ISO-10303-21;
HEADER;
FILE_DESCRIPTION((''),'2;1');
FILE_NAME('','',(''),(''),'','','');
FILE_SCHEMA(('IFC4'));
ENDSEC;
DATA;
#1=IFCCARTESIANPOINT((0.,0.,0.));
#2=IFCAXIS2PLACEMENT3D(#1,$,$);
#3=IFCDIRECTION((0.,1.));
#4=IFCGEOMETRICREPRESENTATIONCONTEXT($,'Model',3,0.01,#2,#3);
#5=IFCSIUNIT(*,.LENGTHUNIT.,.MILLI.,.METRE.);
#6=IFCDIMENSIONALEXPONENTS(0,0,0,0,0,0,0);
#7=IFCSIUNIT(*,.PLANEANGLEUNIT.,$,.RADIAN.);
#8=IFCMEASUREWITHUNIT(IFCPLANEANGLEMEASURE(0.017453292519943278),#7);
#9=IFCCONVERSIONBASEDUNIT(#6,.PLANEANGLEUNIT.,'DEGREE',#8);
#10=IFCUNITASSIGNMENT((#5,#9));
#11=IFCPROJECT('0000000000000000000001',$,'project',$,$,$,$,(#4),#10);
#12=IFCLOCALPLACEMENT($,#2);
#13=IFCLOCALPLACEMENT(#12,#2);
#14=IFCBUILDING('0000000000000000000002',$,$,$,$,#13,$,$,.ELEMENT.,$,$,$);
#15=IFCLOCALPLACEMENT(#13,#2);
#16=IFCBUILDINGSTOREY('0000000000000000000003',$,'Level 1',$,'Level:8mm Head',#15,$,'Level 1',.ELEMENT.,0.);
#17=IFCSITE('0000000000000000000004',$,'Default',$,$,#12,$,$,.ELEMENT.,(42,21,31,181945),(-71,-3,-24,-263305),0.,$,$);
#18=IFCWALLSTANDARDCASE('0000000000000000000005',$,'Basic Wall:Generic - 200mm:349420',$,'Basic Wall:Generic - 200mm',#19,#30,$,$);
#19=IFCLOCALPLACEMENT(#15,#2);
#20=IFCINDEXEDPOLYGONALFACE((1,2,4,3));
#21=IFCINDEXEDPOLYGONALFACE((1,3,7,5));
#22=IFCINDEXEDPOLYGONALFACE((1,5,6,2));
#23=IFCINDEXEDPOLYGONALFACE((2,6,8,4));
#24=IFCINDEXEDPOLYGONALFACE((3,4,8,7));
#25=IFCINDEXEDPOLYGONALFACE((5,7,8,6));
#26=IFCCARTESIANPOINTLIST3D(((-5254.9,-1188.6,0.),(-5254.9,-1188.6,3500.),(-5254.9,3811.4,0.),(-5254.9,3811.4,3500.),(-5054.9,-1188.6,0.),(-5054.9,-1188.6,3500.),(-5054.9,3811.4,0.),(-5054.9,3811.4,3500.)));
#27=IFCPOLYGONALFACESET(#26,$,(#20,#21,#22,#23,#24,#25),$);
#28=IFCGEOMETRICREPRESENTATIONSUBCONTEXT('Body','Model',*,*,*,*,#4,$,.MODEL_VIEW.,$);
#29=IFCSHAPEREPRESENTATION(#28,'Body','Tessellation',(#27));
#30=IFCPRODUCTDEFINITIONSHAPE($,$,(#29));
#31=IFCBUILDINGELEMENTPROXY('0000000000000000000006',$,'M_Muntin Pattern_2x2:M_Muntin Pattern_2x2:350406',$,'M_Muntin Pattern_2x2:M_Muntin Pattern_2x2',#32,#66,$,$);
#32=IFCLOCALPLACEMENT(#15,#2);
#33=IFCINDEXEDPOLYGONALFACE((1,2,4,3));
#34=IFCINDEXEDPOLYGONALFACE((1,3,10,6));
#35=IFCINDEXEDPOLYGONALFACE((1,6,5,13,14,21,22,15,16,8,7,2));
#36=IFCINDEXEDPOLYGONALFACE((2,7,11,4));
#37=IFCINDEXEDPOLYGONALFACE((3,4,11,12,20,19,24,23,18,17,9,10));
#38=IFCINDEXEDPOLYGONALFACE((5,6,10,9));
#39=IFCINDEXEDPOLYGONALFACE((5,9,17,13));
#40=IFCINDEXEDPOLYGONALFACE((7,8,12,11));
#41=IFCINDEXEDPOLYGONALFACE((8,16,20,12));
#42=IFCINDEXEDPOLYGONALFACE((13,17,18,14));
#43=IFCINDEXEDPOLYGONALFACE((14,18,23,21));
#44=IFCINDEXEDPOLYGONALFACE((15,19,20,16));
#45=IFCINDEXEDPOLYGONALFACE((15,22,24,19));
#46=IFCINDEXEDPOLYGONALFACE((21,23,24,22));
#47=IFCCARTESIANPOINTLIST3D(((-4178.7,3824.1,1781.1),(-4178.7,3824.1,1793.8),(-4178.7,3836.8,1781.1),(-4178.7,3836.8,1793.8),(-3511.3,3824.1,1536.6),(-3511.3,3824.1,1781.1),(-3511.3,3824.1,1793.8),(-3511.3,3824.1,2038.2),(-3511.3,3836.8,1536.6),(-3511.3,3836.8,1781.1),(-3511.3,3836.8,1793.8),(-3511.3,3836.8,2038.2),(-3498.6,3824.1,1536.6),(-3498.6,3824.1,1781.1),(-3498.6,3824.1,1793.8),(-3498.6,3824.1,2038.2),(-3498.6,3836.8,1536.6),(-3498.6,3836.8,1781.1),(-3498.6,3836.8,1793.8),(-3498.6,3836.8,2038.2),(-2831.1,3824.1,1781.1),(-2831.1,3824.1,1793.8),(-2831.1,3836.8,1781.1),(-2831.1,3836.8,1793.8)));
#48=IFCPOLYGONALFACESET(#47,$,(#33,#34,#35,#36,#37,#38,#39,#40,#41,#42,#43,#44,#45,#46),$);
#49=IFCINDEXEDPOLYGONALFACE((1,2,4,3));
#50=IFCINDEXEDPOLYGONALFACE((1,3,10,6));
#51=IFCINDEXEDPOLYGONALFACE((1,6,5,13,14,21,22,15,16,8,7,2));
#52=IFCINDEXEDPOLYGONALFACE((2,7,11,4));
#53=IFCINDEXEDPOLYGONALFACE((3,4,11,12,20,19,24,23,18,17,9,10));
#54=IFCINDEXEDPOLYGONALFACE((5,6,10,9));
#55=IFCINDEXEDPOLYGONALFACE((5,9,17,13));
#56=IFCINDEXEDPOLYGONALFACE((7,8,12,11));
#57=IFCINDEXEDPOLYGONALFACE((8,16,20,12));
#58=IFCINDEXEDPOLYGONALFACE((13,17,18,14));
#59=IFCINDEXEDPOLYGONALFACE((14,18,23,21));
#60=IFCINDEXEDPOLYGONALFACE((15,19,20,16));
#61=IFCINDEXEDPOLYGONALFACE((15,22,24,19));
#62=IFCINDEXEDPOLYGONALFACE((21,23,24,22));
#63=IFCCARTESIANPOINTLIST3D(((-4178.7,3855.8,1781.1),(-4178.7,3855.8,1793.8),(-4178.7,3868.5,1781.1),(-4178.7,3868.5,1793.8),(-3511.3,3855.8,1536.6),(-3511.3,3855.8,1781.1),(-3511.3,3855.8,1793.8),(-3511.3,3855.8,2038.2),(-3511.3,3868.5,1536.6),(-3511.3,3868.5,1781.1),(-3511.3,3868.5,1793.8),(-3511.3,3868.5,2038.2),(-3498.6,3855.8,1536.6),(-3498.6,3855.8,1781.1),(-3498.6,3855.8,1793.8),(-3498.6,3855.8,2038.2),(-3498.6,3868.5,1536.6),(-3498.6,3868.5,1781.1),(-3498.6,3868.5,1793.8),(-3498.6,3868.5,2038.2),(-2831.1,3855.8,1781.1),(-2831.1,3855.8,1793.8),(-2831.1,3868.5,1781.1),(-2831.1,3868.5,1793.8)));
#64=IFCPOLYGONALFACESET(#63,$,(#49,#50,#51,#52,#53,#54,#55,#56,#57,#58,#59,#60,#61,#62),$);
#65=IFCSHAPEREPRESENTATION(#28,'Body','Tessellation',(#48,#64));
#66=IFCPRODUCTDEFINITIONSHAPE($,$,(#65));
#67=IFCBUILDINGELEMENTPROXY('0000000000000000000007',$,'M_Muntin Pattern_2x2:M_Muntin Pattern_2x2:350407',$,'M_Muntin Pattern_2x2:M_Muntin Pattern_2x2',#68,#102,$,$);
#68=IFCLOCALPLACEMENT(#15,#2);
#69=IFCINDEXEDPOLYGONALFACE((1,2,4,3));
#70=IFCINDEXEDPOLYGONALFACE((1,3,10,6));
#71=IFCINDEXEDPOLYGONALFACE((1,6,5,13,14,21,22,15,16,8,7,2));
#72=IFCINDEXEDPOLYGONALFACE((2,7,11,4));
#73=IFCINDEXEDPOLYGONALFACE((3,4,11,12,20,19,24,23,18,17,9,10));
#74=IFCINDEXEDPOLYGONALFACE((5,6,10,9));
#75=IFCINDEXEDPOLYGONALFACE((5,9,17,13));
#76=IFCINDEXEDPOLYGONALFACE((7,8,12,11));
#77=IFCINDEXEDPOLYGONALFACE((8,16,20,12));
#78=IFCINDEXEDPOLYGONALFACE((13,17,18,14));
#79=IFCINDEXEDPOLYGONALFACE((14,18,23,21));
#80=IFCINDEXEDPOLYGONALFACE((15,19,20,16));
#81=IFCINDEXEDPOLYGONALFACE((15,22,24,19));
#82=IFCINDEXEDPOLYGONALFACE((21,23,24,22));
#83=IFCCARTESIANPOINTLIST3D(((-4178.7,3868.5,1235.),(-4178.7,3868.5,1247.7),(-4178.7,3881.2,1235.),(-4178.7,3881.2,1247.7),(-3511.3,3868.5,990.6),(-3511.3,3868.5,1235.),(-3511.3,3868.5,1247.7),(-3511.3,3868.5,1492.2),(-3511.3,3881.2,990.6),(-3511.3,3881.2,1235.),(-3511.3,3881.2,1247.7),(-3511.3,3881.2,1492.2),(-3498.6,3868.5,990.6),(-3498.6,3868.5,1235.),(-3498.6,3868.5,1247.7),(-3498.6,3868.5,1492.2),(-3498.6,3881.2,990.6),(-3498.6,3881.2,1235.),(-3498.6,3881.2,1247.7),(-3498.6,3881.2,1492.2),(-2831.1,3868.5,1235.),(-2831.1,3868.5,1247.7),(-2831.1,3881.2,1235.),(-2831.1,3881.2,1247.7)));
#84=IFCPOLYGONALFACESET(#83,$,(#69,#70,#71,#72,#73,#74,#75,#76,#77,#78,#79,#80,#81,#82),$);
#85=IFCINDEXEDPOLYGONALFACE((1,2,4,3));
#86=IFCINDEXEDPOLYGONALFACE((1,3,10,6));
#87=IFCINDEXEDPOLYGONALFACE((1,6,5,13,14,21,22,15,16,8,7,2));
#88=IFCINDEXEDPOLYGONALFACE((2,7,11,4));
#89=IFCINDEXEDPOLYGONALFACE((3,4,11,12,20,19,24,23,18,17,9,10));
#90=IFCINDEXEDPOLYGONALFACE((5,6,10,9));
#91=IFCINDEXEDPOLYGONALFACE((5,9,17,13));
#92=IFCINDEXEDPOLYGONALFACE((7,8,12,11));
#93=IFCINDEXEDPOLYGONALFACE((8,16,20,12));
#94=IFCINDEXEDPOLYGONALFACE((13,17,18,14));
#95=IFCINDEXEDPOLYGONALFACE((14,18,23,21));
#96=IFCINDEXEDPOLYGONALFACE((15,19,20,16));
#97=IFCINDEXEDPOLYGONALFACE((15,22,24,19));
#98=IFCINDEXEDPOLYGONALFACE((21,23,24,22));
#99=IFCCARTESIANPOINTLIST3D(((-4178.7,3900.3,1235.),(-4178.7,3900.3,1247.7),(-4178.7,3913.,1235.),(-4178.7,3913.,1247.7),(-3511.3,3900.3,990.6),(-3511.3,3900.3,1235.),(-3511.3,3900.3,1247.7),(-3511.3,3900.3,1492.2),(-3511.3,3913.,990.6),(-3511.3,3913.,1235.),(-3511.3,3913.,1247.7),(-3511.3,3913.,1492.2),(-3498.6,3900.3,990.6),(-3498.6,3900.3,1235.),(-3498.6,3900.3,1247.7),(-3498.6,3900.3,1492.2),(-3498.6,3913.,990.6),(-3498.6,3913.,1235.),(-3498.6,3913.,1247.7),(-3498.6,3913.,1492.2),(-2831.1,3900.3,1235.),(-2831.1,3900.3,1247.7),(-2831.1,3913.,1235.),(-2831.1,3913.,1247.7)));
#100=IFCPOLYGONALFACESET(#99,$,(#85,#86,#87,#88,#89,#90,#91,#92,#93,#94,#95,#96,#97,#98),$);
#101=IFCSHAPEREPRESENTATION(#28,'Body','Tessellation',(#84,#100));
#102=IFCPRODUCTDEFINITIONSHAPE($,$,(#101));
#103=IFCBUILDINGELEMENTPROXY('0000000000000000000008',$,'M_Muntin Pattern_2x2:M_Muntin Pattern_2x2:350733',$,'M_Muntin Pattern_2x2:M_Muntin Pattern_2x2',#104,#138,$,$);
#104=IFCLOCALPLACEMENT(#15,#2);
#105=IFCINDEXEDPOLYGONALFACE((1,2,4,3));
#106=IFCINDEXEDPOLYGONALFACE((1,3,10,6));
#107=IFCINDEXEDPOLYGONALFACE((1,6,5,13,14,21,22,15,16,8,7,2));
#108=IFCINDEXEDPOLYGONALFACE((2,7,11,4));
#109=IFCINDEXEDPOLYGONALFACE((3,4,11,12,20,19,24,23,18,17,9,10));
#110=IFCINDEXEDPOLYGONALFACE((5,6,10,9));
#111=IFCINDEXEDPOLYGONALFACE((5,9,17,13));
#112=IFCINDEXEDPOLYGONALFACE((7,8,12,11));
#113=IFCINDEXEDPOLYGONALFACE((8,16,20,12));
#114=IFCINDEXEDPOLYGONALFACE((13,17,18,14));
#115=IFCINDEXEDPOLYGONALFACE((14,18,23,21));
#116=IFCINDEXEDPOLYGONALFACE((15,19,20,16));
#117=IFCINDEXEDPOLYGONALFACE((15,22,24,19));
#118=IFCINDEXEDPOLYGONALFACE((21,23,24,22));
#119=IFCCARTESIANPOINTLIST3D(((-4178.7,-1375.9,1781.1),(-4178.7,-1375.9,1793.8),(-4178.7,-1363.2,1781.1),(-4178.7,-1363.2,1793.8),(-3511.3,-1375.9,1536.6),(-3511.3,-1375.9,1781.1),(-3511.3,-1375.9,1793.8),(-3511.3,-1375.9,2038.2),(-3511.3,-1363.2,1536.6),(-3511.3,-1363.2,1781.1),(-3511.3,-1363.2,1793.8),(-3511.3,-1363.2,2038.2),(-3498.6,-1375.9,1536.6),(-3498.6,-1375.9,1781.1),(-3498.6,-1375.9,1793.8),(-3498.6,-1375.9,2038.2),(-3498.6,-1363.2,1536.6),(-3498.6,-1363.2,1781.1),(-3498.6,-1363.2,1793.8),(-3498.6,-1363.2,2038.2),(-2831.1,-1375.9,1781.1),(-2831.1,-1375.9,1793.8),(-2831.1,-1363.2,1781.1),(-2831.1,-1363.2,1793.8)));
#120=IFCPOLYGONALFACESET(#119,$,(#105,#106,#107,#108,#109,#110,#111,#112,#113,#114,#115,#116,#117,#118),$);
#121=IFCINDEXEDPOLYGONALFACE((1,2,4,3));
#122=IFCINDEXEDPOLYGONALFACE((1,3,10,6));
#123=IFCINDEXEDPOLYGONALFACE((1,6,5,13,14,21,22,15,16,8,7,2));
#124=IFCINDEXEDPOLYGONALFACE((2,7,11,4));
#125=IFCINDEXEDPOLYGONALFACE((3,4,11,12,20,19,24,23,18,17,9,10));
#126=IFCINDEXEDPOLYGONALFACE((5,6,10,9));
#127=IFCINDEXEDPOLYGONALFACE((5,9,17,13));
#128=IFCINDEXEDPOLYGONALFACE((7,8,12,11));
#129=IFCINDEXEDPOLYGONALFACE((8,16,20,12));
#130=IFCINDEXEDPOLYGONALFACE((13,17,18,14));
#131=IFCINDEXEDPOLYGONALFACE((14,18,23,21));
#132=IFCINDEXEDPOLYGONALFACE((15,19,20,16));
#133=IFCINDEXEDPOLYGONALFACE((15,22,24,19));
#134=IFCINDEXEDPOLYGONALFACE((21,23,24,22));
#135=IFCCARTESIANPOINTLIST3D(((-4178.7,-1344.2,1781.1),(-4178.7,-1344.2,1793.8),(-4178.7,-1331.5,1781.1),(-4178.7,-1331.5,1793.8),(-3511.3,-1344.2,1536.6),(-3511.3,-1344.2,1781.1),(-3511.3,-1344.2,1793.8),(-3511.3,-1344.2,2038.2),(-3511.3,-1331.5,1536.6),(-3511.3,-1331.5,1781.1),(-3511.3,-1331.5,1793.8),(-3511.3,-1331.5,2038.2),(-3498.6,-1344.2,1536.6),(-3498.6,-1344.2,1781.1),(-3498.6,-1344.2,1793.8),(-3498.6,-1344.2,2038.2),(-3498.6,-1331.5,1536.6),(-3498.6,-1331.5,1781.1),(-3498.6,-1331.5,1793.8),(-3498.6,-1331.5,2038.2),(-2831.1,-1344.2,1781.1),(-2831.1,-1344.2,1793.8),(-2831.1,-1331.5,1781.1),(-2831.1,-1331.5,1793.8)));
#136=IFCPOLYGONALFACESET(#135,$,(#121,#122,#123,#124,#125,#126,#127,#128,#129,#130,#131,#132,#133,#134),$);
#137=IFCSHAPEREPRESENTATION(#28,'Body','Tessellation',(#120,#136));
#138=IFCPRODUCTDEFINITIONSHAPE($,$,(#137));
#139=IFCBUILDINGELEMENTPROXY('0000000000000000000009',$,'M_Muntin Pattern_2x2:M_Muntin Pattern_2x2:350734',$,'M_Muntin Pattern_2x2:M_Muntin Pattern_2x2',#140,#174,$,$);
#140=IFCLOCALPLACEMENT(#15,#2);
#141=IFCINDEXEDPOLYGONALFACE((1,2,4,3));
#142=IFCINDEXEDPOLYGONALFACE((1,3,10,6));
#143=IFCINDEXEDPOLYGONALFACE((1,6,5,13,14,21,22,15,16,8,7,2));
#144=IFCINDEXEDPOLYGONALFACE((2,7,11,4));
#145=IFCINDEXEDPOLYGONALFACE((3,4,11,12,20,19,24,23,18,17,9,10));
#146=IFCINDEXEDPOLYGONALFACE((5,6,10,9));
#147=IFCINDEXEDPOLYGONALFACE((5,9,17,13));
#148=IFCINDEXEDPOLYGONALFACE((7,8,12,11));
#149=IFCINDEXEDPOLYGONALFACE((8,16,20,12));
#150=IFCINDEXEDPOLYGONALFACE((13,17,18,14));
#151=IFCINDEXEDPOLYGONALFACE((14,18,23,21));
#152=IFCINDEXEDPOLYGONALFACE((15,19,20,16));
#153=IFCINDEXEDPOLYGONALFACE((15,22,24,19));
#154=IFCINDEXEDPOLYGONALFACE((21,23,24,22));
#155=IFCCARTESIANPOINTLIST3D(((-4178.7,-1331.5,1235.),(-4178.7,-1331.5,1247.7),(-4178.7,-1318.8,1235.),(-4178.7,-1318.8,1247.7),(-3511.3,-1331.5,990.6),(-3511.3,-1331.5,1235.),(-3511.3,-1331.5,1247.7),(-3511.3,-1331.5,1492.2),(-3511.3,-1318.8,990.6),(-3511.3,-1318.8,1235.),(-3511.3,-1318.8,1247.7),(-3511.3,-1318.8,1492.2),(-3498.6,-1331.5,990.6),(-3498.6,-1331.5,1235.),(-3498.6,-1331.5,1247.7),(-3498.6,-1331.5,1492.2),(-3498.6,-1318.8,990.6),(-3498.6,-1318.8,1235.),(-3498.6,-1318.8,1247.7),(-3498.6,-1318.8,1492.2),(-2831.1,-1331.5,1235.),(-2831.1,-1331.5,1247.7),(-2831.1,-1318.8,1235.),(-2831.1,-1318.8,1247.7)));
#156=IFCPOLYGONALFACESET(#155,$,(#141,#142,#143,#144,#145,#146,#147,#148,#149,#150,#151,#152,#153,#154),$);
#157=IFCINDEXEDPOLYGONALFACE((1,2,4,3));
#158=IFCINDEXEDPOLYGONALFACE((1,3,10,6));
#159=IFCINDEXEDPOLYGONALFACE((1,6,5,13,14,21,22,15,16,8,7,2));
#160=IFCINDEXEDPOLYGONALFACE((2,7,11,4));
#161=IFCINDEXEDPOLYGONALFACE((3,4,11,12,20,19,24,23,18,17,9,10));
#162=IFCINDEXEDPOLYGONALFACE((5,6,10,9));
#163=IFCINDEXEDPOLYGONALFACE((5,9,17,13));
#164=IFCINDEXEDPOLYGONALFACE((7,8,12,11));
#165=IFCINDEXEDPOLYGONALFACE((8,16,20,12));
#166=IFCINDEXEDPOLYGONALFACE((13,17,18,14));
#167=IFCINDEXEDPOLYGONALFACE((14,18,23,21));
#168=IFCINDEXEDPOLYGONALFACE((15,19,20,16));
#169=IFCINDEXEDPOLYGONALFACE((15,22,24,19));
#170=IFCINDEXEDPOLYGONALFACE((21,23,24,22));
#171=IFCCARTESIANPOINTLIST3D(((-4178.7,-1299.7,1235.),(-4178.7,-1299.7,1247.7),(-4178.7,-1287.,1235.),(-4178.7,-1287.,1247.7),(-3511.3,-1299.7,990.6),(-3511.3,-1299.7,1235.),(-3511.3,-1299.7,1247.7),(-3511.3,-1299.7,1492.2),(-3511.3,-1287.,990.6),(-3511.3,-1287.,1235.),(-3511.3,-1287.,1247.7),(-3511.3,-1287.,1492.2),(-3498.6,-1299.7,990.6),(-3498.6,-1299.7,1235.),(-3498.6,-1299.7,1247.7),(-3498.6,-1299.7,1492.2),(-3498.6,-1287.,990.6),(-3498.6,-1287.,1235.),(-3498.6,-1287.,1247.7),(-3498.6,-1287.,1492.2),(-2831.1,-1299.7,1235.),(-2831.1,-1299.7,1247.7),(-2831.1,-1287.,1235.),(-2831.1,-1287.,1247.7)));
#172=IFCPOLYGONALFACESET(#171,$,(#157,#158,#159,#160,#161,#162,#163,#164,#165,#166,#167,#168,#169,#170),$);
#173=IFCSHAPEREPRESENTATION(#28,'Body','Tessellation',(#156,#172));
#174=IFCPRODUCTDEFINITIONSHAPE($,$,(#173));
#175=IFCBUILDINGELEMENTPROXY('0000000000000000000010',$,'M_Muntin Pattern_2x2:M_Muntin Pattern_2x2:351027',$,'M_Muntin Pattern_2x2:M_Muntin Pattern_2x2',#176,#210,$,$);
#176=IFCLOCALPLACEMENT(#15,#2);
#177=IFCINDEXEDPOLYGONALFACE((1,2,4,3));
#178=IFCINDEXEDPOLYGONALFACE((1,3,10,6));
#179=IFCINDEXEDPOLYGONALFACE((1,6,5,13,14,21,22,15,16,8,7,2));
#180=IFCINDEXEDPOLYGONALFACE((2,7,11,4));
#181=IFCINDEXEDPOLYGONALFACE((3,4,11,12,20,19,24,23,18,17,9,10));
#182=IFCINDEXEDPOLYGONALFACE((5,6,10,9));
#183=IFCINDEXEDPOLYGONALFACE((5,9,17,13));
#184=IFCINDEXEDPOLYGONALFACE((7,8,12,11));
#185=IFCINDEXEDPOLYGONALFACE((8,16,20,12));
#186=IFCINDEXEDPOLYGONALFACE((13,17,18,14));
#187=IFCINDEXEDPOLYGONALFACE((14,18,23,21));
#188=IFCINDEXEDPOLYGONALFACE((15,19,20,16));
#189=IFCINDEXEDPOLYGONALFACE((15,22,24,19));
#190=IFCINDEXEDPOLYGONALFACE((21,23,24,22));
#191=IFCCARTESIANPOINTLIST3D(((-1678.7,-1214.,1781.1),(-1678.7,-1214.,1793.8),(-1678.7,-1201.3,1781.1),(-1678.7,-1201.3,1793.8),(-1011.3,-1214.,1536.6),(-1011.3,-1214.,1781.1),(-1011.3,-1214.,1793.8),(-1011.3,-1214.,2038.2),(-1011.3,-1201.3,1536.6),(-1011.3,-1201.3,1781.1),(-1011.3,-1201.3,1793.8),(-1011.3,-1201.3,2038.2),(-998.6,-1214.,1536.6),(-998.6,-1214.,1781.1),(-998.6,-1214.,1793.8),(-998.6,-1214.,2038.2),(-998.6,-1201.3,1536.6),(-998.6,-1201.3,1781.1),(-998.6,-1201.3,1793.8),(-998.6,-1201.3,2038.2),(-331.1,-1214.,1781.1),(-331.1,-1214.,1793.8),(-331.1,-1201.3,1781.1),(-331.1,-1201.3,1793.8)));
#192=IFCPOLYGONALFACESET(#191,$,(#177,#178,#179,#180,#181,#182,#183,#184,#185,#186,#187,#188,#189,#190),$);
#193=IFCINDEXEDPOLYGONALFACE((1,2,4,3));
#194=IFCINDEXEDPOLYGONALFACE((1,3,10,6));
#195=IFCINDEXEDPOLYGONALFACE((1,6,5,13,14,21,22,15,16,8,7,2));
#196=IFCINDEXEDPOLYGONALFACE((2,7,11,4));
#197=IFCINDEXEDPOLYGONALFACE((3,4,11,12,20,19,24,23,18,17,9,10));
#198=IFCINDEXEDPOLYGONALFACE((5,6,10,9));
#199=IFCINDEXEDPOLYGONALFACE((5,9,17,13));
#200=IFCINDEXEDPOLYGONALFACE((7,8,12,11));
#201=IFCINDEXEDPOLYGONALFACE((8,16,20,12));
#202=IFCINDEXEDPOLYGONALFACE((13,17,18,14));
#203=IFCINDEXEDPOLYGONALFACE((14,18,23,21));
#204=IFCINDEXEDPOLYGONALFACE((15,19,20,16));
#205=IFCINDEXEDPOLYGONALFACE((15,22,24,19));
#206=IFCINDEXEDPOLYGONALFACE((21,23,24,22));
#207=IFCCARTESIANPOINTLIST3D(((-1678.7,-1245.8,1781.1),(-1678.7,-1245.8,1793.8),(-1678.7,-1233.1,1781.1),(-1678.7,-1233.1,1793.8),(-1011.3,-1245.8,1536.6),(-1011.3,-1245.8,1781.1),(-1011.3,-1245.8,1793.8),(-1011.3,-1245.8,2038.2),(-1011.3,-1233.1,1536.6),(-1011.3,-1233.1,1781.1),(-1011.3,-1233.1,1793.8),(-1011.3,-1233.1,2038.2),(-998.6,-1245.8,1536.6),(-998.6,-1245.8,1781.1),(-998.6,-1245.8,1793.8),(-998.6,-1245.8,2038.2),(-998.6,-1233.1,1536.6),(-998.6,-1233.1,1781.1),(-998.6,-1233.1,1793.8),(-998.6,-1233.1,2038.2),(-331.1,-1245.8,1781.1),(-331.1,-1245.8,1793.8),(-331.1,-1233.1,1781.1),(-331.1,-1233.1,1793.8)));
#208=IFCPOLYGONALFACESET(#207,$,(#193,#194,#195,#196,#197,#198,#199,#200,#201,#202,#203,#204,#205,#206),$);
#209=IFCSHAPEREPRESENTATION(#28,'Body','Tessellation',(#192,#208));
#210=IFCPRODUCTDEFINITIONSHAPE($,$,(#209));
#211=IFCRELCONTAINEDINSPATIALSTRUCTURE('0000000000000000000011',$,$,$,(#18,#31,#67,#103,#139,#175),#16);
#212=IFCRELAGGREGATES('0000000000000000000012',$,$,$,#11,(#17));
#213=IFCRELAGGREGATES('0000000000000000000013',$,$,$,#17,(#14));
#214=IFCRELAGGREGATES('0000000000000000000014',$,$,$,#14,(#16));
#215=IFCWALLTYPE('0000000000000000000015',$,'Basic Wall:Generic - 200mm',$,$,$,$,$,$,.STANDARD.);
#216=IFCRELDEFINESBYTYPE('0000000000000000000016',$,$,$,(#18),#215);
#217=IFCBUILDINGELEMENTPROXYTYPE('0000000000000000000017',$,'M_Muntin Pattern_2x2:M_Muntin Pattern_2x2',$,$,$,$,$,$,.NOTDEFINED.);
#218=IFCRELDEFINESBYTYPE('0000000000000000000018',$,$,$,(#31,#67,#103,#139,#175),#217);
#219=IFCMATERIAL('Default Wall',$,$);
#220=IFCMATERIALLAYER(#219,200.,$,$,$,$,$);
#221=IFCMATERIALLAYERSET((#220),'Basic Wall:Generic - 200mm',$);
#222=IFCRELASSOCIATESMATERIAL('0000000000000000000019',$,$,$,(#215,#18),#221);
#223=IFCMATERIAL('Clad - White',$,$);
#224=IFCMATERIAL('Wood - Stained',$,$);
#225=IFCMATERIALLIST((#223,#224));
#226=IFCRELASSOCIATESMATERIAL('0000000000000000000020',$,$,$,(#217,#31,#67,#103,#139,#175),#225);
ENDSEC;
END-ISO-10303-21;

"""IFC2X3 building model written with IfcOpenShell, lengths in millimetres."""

from ifc_helpers import new_model, entity, si_unit, converted_unit, direction, frame, frame_2d, origin, place, context, subcontext, project, spatial, polyline, rectangle, outline, extrude, source, transform, mapped, material, material_list, layer, layer_set, layer_usage, type_object, type_shapes, element, save


model = new_model("IFC2X3")

# Units and contexts
model_context = context("Model", 3, precision=0.01, world=origin(), true_north=direction((0.0, 1.0)))
body_context = subcontext(model_context, "Body", "Model", "MODEL_VIEW")
ifc_project = project(units=[si_unit("LENGTHUNIT", "METRE", prefix="MILLI"), converted_unit("PLANEANGLEUNIT", "DEGREE", entity("IfcPlaneAngleMeasure", 0.017453292519943278), si_unit("PLANEANGLEUNIT", "RADIAN"), dimensions=[0, 0, 0, 0, 0, 0, 0])], contexts=[model_context])

# Site, building, storey
site_placement = place(None, origin())
site = spatial("IfcSite", under=ifc_project, at=site_placement, Name="Default", CompositionType="ELEMENT", RefLatitude=(42, 21, 31, 181945), RefLongitude=(-71, -3, -24, -263305), RefElevation=0.0)
building_placement = place(site_placement, origin())
building = spatial("IfcBuilding", under=site, at=building_placement, CompositionType="ELEMENT")
storey_placement = place(building_placement, origin())
storey = spatial("IfcBuildingStorey", under=building, at=storey_placement, Name="Level 1", ObjectType="Level:8mm Head", LongName="Level 1", CompositionType="ELEMENT", Elevation=0.0)

# Shared definitions
ifc_material_1 = material(Name="Default Wall")
ifc_layer = layer(ifc_material_1, 200.0)
ifc_layer_set = layer_set([ifc_layer], Name="Basic Wall:Generic - 200mm")
wall_type = type_object("IfcWallType", Name="Basic Wall:Generic - 200mm", PredefinedType="STANDARD", material=ifc_layer_set)
ifc_material_2 = material(Name="Wood - Stained")

# Wall
ifc_layer_usage_1 = layer_usage(ifc_layer_set, "AXIS2", "NEGATIVE", 100.0)
wall_1_placement = place(storey_placement, frame((-5154.9, -1188.6, 0.0), z_axis=(0.0, 0.0, 1.0), x_axis=(0.0, 1.0, 0.0)))
element("IfcWallStandardCase", 1, at=wall_1_placement, inside=storey, type_object=wall_type, material=ifc_layer_usage_1, Name="Basic Wall:Generic - 200mm:349420", ObjectType="Basic Wall:Generic - 200mm", context=body_context, shape_type="SweptSolid", body=[
    extrude(rectangle(XDim=5000.0, YDim=200.0, at=frame_2d((2500.0, 0.0), x_axis=(-1.0, 0.0))), origin(), (0.0, 0.0, 1.0), 3500.0),
])

# Building element proxies
ifc_material_3 = material(Name="Clad - White")
ifc_material_list_1 = material_list([ifc_material_3, ifc_material_2])
building_element_proxy_type_1 = type_object("IfcBuildingElementProxyType", Name="M_Muntin Pattern_2x2:M_Muntin Pattern_2x2", PredefinedType="NOTDEFINED", material=ifc_material_list_1)
shared_shape_1 = source(origin(), body_context, "Body", "SweptSolid", [
    extrude(outline(polyline([(6.4, -6.4), (250.8, -6.4), (250.8, 6.3), (6.4, 6.3), (6.4, 673.8), (-6.3, 673.8), (-6.3, 6.3), (-250.8, 6.3), (-250.8, -6.4), (-6.3, -6.4), (-6.3, -673.8), (6.4, -673.8), (6.4, -6.4)])), frame((0.0, 9.5, 250.8), z_axis=(0.0, 1.0, 0.0), x_axis=(0.0, 0.0, 1.0)), (0.0, 0.0, 1.0), 12.7),
    extrude(outline(polyline([(6.4, -6.4), (250.8, -6.4), (250.8, 6.3), (6.4, 6.3), (6.4, 673.8), (-6.3, 673.8), (-6.3, 6.3), (-250.8, 6.3), (-250.8, -6.4), (-6.3, -6.4), (-6.3, -673.8), (6.4, -673.8), (6.4, -6.4)])), frame((0.0, -22.2, 250.8), z_axis=(0.0, 1.0, 0.0), x_axis=(0.0, 0.0, 1.0)), (0.0, 0.0, 1.0), 12.7),
])
type_shapes(building_element_proxy_type_1, [shared_shape_1])
for number, where, z_axis, x_axis, name in (
    (2, (-3504.9, 3846.3, 1536.6), (0.0, 0.0, 1.0), (-1.0, 0.0, 0.0), "M_Muntin Pattern_2x2:M_Muntin Pattern_2x2:350406"),
    (3, (-3504.9, 3890.7, 990.6), (0.0, 0.0, 1.0), (-1.0, 0.0, 0.0), "M_Muntin Pattern_2x2:M_Muntin Pattern_2x2:350407"),
    (4, (-3504.9, -1353.7, 1536.6), (0.0, 0.0, 1.0), (-1.0, 0.0, 0.0), "M_Muntin Pattern_2x2:M_Muntin Pattern_2x2:350733"),
    (5, (-3504.9, -1309.3, 990.6), (0.0, 0.0, 1.0), (-1.0, 0.0, 0.0), "M_Muntin Pattern_2x2:M_Muntin Pattern_2x2:350734"),
):
    element("IfcBuildingElementProxy", number, at=place(storey_placement, frame(where, z_axis=z_axis, x_axis=x_axis)), inside=storey, type_object=building_element_proxy_type_1, material=ifc_material_list_1, Name=name, ObjectType="M_Muntin Pattern_2x2:M_Muntin Pattern_2x2", context=body_context, shape_type="MappedRepresentation", body=[
        mapped(shared_shape_1, transform((0.0, 0.0, 0.0), scale=1.0)),
    ])
for number, where, name in (
    (6, (-1004.9, -1223.6, 1536.6), "M_Muntin Pattern_2x2:M_Muntin Pattern_2x2:351027"),
):
    element("IfcBuildingElementProxy", number, at=place(storey_placement, frame(where)), inside=storey, type_object=building_element_proxy_type_1, material=ifc_material_list_1, Name=name, ObjectType="M_Muntin Pattern_2x2:M_Muntin Pattern_2x2", context=body_context, shape_type="MappedRepresentation", body=[
        mapped(shared_shape_1, transform((0.0, 0.0, 0.0), scale=1.0)),
    ])

save(model, "model.ifc")
